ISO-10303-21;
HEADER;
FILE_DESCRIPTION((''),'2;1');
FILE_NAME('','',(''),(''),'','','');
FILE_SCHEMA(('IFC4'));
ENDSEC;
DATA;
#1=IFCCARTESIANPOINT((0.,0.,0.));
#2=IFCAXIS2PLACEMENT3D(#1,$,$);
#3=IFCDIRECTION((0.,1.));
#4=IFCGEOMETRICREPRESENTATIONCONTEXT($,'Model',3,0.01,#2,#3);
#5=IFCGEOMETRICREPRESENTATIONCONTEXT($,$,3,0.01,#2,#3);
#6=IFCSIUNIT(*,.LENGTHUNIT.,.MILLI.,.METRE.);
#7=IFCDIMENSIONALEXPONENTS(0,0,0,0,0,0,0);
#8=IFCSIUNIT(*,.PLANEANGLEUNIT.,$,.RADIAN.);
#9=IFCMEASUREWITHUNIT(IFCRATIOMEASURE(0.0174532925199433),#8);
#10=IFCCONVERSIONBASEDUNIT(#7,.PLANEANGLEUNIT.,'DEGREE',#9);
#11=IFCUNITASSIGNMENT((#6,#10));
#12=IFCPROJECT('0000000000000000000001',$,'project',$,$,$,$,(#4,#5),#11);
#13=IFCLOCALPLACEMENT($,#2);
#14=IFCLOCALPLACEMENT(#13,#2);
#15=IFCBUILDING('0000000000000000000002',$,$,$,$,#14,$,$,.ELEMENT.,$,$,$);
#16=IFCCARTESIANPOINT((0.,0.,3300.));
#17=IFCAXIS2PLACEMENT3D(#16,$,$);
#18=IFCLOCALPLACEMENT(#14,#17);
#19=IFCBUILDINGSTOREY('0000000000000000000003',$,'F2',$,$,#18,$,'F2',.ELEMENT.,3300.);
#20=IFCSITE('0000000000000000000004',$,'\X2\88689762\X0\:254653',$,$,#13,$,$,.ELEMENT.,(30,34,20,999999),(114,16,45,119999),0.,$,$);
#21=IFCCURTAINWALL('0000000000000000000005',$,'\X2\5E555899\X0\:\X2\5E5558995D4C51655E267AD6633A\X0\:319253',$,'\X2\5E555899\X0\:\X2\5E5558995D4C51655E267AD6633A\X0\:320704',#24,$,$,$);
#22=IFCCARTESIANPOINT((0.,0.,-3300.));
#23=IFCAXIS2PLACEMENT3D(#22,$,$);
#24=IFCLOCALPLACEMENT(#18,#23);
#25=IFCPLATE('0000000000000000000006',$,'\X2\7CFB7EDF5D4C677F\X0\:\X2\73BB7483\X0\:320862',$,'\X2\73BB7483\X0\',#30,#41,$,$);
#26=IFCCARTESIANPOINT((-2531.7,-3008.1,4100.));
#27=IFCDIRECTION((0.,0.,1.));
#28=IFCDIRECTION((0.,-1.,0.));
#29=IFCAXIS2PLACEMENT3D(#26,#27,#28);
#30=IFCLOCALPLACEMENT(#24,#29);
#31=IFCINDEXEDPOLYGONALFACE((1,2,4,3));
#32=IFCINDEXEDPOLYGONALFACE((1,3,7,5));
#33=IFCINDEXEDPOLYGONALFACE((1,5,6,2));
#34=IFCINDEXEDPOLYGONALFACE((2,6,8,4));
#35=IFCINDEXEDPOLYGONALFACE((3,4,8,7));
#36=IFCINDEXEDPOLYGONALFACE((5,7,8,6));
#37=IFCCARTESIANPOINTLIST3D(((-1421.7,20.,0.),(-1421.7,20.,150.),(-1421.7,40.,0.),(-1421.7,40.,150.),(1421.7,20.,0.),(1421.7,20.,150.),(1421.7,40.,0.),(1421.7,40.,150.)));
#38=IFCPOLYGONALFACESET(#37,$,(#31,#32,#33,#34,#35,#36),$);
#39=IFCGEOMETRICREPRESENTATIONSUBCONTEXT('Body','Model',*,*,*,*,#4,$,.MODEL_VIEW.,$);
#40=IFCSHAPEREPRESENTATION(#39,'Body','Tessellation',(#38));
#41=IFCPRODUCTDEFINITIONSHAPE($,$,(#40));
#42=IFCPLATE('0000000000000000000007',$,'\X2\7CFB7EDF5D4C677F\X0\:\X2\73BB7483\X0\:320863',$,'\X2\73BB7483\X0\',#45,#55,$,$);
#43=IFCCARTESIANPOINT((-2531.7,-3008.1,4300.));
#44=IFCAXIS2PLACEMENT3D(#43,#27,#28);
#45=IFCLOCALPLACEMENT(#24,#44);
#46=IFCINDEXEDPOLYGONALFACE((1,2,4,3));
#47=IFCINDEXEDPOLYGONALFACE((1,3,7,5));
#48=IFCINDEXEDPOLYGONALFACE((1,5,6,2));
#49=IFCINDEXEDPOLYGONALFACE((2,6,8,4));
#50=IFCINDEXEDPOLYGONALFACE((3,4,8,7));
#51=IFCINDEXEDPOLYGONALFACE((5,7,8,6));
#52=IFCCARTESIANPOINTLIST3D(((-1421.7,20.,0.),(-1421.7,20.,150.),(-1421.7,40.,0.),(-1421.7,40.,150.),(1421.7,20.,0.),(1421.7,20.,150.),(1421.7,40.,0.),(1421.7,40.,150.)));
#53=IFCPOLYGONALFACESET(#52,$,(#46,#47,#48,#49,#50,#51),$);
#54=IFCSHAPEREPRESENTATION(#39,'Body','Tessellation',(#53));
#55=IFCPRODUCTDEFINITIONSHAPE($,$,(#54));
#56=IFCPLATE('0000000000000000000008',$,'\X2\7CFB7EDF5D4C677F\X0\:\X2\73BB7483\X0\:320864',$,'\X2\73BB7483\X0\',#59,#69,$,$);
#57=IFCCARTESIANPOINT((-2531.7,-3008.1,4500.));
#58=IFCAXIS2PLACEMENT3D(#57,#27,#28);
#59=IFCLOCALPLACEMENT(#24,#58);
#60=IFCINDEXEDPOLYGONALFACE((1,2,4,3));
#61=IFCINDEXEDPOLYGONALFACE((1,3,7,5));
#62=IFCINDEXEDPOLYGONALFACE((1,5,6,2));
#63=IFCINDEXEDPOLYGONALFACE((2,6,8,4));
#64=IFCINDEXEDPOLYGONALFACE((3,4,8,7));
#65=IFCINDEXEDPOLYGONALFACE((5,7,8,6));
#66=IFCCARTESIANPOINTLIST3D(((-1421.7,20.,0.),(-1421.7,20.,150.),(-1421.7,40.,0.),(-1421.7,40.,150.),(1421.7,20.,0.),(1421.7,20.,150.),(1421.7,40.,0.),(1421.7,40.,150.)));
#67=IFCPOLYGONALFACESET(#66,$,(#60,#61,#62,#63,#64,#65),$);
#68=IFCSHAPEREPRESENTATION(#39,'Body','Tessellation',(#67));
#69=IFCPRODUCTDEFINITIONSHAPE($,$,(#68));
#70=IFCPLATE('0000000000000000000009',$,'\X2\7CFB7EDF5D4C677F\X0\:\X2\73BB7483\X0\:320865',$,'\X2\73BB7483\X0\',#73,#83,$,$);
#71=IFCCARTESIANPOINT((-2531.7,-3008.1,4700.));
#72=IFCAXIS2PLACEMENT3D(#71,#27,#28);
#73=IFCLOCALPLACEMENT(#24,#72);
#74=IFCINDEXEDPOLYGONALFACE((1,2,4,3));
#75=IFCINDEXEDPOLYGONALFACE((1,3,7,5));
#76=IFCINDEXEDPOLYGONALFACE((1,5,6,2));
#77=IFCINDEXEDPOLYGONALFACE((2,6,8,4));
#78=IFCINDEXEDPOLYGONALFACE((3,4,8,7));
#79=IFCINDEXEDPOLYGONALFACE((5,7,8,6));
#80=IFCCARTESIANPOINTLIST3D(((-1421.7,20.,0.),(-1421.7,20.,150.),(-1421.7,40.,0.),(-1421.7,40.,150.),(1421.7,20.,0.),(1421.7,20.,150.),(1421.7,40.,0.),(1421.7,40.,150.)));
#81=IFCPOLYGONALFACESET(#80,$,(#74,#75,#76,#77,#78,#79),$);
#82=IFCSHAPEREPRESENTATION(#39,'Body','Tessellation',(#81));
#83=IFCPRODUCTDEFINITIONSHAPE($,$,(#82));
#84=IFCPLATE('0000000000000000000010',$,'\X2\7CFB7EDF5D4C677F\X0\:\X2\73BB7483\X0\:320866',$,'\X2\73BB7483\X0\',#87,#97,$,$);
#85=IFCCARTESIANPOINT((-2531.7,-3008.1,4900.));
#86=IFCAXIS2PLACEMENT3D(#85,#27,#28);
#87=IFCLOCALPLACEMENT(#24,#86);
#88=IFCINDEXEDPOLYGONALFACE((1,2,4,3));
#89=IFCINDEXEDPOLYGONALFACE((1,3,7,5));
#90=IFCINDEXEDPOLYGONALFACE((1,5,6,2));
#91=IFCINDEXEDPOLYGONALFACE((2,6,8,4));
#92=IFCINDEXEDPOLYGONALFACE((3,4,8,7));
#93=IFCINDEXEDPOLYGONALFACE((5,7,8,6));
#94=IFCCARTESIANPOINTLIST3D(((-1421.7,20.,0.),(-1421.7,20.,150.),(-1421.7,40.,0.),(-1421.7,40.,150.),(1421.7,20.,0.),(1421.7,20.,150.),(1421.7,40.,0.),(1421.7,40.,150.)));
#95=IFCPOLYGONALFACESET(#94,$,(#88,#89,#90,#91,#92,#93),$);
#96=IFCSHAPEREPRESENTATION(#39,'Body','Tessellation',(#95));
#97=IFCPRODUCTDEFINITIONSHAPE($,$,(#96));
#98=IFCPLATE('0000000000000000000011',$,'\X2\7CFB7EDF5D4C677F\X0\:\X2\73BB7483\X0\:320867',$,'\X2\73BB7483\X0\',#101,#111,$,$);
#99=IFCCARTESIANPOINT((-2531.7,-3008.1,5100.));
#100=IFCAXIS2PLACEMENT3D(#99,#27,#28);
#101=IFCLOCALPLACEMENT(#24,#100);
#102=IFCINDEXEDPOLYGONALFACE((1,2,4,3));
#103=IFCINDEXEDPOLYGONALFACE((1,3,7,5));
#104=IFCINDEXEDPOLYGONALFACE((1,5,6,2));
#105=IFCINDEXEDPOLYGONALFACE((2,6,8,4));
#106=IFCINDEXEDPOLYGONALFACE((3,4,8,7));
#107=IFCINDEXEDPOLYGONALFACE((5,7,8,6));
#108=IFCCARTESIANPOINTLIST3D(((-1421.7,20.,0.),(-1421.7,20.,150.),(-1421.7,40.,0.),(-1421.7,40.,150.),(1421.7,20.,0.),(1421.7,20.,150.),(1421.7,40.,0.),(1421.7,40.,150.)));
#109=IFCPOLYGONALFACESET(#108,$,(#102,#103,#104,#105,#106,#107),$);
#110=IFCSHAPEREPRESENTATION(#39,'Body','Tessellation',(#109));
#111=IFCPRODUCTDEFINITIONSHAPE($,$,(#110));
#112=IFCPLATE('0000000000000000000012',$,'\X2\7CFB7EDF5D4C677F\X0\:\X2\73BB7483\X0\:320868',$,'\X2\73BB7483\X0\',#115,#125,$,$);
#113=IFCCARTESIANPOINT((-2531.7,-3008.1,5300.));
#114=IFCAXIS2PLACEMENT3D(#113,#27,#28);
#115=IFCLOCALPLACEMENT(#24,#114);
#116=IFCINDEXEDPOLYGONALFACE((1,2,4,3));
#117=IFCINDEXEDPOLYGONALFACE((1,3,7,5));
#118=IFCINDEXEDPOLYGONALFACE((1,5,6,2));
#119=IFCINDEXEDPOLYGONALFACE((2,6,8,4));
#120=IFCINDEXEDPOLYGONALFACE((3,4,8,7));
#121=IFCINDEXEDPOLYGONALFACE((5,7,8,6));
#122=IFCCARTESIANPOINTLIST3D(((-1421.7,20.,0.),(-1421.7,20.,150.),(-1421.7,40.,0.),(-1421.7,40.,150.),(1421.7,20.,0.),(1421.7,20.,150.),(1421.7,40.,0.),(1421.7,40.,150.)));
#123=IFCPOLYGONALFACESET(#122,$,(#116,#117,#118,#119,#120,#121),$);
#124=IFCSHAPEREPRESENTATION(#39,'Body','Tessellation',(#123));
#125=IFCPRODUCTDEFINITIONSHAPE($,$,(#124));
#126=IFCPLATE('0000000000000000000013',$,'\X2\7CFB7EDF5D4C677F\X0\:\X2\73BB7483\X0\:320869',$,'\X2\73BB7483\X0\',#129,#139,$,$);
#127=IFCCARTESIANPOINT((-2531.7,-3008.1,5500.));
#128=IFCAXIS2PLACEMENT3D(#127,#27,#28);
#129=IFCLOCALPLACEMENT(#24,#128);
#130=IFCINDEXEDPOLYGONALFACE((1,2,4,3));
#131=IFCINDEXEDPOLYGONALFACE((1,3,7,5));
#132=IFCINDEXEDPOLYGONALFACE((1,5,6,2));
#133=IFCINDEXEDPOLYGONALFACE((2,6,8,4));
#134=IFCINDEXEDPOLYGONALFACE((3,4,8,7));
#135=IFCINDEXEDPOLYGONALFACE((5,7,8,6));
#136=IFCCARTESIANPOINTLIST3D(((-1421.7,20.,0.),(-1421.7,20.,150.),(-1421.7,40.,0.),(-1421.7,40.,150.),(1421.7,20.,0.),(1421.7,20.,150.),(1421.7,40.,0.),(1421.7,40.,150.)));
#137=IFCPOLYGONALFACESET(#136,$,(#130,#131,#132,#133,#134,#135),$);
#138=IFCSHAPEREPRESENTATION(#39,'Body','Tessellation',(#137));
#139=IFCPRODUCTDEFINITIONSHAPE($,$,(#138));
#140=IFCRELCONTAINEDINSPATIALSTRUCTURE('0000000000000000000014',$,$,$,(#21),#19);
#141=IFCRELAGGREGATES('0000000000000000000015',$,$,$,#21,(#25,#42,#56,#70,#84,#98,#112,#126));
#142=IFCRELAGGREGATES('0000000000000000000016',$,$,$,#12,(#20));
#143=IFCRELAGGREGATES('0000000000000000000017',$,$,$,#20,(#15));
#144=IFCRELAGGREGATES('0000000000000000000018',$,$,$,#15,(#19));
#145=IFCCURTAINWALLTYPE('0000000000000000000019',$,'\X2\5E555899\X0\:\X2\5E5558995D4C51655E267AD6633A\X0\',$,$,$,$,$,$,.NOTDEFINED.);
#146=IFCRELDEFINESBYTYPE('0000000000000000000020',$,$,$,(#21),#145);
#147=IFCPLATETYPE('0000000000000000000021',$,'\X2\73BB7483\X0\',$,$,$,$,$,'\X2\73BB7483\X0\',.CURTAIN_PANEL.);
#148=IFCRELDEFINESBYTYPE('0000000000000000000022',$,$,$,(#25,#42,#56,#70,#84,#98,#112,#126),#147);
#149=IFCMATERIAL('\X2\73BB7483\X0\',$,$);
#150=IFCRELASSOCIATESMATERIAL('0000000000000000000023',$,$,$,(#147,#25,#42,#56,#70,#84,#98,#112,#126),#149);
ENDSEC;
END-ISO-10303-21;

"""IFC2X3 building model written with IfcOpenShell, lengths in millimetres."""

from ifc_helpers import new_model, entity, si_unit, converted_unit, direction, frame, frame_2d, origin, place, context, subcontext, project, spatial, rectangle, extrude, source, transform, mapped, material, type_object, type_shapes, element, aggregate, save


model = new_model("IFC2X3")

# Units and contexts
model_context = context("Model", 3, precision=0.01, world=origin(), true_north=direction((0.0, 1.0)))
context_of_model = context(None, 3, precision=0.01, world=origin(), true_north=direction((0.0, 1.0)))
body_context = subcontext(model_context, "Body", "Model", "MODEL_VIEW")
ifc_project = project(units=[si_unit("LENGTHUNIT", "METRE", prefix="MILLI"), converted_unit("PLANEANGLEUNIT", "DEGREE", entity("IfcRatioMeasure", 0.0174532925199433), si_unit("PLANEANGLEUNIT", "RADIAN"), dimensions=[0, 0, 0, 0, 0, 0, 0])], contexts=[model_context, context_of_model])

# Site, building, storey
site_placement = place(None, origin())
site = spatial("IfcSite", under=ifc_project, at=site_placement, Name="表面:254653", CompositionType="ELEMENT", RefLatitude=(30, 34, 20, 999999), RefLongitude=(114, 16, 45, 119999), RefElevation=0.0)
building_placement = place(site_placement, origin())
building = spatial("IfcBuilding", under=site, at=building_placement, CompositionType="ELEMENT")
storey_placement = place(building_placement, frame((0.0, 0.0, 3300.0)))
storey = spatial("IfcBuildingStorey", under=building, at=storey_placement, Name="F2", LongName="F2", CompositionType="ELEMENT", Elevation=3300.0)

# Curtain wall, plates
curtain_wall_type = type_object("IfcCurtainWallType", Name="幕墙:幕墙嵌入带竖挺", PredefinedType="NOTDEFINED")
curtain_wall_placement = place(storey_placement, frame((0.0, 0.0, -3300.0)))
curtain_wall = element("IfcCurtainWall", 1, at=curtain_wall_placement, inside=storey, type_object=curtain_wall_type, Name="幕墙:幕墙嵌入带竖挺:319253", ObjectType="幕墙:幕墙嵌入带竖挺:320704")
ifc_material = material(Name="玻璃")
plate_type_1 = type_object("IfcPlateType", Name="玻璃", ElementType="玻璃", PredefinedType="CURTAIN_PANEL", material=ifc_material)
shared_shape_1 = source(origin(), body_context, "Body", "SweptSolid", [
    extrude(rectangle(XDim=20.0, YDim=2843.3, at=frame_2d((0.0, 0.0), x_axis=(1.0, 0.0))), frame((0.0, 30.0, 0.0), z_axis=(0.0, 0.0, 1.0), x_axis=(0.0, 1.0, 0.0)), (0.0, 0.0, 1.0), 150.0),
])
type_shapes(plate_type_1, [shared_shape_1])
plate_1_placement = place(curtain_wall_placement, frame((-2531.7, -3008.1, 4100.0), z_axis=(0.0, 0.0, 1.0), x_axis=(0.0, -1.0, 0.0)))
plate_1 = element("IfcPlate", 2, at=plate_1_placement, type_object=plate_type_1, material=ifc_material, Name="系统嵌板:玻璃:320862", ObjectType="玻璃", context=body_context, shape_type="MappedRepresentation", body=[
    mapped(shared_shape_1, transform((0.0, 0.0, 0.0), scale=1.0)),
])
plate_2_placement = place(curtain_wall_placement, frame((-2531.7, -3008.1, 4300.0), z_axis=(0.0, 0.0, 1.0), x_axis=(0.0, -1.0, 0.0)))
plate_2 = element("IfcPlate", 3, at=plate_2_placement, type_object=plate_type_1, material=ifc_material, Name="系统嵌板:玻璃:320863", ObjectType="玻璃", context=body_context, shape_type="MappedRepresentation", body=[
    mapped(shared_shape_1, transform((0.0, 0.0, 0.0), scale=1.0)),
])
plate_3_placement = place(curtain_wall_placement, frame((-2531.7, -3008.1, 4500.0), z_axis=(0.0, 0.0, 1.0), x_axis=(0.0, -1.0, 0.0)))
plate_3 = element("IfcPlate", 4, at=plate_3_placement, type_object=plate_type_1, material=ifc_material, Name="系统嵌板:玻璃:320864", ObjectType="玻璃", context=body_context, shape_type="MappedRepresentation", body=[
    mapped(shared_shape_1, transform((0.0, 0.0, 0.0), scale=1.0)),
])
plate_4_placement = place(curtain_wall_placement, frame((-2531.7, -3008.1, 4700.0), z_axis=(0.0, 0.0, 1.0), x_axis=(0.0, -1.0, 0.0)))
plate_4 = element("IfcPlate", 5, at=plate_4_placement, type_object=plate_type_1, material=ifc_material, Name="系统嵌板:玻璃:320865", ObjectType="玻璃", context=body_context, shape_type="MappedRepresentation", body=[
    mapped(shared_shape_1, transform((0.0, 0.0, 0.0), scale=1.0)),
])
plate_5_placement = place(curtain_wall_placement, frame((-2531.7, -3008.1, 4900.0), z_axis=(0.0, 0.0, 1.0), x_axis=(0.0, -1.0, 0.0)))
plate_5 = element("IfcPlate", 6, at=plate_5_placement, type_object=plate_type_1, material=ifc_material, Name="系统嵌板:玻璃:320866", ObjectType="玻璃", context=body_context, shape_type="MappedRepresentation", body=[
    mapped(shared_shape_1, transform((0.0, 0.0, 0.0), scale=1.0)),
])
plate_6_placement = place(curtain_wall_placement, frame((-2531.7, -3008.1, 5100.0), z_axis=(0.0, 0.0, 1.0), x_axis=(0.0, -1.0, 0.0)))
plate_6 = element("IfcPlate", 7, at=plate_6_placement, type_object=plate_type_1, material=ifc_material, Name="系统嵌板:玻璃:320867", ObjectType="玻璃", context=body_context, shape_type="MappedRepresentation", body=[
    mapped(shared_shape_1, transform((0.0, 0.0, 0.0), scale=1.0)),
])
plate_7_placement = place(curtain_wall_placement, frame((-2531.7, -3008.1, 5300.0), z_axis=(0.0, 0.0, 1.0), x_axis=(0.0, -1.0, 0.0)))
plate_7 = element("IfcPlate", 8, at=plate_7_placement, type_object=plate_type_1, material=ifc_material, Name="系统嵌板:玻璃:320868", ObjectType="玻璃", context=body_context, shape_type="MappedRepresentation", body=[
    mapped(shared_shape_1, transform((0.0, 0.0, 0.0), scale=1.0)),
])
plate_8_placement = place(curtain_wall_placement, frame((-2531.7, -3008.1, 5500.0), z_axis=(0.0, 0.0, 1.0), x_axis=(0.0, -1.0, 0.0)))
plate_8 = element("IfcPlate", 9, at=plate_8_placement, type_object=plate_type_1, material=ifc_material, Name="系统嵌板:玻璃:320869", ObjectType="玻璃", context=body_context, shape_type="MappedRepresentation", body=[
    mapped(shared_shape_1, transform((0.0, 0.0, 0.0), scale=1.0)),
])
aggregate(curtain_wall, [plate_1, plate_2, plate_3, plate_4, plate_5, plate_6, plate_7, plate_8])

save(model, "model.ifc")
